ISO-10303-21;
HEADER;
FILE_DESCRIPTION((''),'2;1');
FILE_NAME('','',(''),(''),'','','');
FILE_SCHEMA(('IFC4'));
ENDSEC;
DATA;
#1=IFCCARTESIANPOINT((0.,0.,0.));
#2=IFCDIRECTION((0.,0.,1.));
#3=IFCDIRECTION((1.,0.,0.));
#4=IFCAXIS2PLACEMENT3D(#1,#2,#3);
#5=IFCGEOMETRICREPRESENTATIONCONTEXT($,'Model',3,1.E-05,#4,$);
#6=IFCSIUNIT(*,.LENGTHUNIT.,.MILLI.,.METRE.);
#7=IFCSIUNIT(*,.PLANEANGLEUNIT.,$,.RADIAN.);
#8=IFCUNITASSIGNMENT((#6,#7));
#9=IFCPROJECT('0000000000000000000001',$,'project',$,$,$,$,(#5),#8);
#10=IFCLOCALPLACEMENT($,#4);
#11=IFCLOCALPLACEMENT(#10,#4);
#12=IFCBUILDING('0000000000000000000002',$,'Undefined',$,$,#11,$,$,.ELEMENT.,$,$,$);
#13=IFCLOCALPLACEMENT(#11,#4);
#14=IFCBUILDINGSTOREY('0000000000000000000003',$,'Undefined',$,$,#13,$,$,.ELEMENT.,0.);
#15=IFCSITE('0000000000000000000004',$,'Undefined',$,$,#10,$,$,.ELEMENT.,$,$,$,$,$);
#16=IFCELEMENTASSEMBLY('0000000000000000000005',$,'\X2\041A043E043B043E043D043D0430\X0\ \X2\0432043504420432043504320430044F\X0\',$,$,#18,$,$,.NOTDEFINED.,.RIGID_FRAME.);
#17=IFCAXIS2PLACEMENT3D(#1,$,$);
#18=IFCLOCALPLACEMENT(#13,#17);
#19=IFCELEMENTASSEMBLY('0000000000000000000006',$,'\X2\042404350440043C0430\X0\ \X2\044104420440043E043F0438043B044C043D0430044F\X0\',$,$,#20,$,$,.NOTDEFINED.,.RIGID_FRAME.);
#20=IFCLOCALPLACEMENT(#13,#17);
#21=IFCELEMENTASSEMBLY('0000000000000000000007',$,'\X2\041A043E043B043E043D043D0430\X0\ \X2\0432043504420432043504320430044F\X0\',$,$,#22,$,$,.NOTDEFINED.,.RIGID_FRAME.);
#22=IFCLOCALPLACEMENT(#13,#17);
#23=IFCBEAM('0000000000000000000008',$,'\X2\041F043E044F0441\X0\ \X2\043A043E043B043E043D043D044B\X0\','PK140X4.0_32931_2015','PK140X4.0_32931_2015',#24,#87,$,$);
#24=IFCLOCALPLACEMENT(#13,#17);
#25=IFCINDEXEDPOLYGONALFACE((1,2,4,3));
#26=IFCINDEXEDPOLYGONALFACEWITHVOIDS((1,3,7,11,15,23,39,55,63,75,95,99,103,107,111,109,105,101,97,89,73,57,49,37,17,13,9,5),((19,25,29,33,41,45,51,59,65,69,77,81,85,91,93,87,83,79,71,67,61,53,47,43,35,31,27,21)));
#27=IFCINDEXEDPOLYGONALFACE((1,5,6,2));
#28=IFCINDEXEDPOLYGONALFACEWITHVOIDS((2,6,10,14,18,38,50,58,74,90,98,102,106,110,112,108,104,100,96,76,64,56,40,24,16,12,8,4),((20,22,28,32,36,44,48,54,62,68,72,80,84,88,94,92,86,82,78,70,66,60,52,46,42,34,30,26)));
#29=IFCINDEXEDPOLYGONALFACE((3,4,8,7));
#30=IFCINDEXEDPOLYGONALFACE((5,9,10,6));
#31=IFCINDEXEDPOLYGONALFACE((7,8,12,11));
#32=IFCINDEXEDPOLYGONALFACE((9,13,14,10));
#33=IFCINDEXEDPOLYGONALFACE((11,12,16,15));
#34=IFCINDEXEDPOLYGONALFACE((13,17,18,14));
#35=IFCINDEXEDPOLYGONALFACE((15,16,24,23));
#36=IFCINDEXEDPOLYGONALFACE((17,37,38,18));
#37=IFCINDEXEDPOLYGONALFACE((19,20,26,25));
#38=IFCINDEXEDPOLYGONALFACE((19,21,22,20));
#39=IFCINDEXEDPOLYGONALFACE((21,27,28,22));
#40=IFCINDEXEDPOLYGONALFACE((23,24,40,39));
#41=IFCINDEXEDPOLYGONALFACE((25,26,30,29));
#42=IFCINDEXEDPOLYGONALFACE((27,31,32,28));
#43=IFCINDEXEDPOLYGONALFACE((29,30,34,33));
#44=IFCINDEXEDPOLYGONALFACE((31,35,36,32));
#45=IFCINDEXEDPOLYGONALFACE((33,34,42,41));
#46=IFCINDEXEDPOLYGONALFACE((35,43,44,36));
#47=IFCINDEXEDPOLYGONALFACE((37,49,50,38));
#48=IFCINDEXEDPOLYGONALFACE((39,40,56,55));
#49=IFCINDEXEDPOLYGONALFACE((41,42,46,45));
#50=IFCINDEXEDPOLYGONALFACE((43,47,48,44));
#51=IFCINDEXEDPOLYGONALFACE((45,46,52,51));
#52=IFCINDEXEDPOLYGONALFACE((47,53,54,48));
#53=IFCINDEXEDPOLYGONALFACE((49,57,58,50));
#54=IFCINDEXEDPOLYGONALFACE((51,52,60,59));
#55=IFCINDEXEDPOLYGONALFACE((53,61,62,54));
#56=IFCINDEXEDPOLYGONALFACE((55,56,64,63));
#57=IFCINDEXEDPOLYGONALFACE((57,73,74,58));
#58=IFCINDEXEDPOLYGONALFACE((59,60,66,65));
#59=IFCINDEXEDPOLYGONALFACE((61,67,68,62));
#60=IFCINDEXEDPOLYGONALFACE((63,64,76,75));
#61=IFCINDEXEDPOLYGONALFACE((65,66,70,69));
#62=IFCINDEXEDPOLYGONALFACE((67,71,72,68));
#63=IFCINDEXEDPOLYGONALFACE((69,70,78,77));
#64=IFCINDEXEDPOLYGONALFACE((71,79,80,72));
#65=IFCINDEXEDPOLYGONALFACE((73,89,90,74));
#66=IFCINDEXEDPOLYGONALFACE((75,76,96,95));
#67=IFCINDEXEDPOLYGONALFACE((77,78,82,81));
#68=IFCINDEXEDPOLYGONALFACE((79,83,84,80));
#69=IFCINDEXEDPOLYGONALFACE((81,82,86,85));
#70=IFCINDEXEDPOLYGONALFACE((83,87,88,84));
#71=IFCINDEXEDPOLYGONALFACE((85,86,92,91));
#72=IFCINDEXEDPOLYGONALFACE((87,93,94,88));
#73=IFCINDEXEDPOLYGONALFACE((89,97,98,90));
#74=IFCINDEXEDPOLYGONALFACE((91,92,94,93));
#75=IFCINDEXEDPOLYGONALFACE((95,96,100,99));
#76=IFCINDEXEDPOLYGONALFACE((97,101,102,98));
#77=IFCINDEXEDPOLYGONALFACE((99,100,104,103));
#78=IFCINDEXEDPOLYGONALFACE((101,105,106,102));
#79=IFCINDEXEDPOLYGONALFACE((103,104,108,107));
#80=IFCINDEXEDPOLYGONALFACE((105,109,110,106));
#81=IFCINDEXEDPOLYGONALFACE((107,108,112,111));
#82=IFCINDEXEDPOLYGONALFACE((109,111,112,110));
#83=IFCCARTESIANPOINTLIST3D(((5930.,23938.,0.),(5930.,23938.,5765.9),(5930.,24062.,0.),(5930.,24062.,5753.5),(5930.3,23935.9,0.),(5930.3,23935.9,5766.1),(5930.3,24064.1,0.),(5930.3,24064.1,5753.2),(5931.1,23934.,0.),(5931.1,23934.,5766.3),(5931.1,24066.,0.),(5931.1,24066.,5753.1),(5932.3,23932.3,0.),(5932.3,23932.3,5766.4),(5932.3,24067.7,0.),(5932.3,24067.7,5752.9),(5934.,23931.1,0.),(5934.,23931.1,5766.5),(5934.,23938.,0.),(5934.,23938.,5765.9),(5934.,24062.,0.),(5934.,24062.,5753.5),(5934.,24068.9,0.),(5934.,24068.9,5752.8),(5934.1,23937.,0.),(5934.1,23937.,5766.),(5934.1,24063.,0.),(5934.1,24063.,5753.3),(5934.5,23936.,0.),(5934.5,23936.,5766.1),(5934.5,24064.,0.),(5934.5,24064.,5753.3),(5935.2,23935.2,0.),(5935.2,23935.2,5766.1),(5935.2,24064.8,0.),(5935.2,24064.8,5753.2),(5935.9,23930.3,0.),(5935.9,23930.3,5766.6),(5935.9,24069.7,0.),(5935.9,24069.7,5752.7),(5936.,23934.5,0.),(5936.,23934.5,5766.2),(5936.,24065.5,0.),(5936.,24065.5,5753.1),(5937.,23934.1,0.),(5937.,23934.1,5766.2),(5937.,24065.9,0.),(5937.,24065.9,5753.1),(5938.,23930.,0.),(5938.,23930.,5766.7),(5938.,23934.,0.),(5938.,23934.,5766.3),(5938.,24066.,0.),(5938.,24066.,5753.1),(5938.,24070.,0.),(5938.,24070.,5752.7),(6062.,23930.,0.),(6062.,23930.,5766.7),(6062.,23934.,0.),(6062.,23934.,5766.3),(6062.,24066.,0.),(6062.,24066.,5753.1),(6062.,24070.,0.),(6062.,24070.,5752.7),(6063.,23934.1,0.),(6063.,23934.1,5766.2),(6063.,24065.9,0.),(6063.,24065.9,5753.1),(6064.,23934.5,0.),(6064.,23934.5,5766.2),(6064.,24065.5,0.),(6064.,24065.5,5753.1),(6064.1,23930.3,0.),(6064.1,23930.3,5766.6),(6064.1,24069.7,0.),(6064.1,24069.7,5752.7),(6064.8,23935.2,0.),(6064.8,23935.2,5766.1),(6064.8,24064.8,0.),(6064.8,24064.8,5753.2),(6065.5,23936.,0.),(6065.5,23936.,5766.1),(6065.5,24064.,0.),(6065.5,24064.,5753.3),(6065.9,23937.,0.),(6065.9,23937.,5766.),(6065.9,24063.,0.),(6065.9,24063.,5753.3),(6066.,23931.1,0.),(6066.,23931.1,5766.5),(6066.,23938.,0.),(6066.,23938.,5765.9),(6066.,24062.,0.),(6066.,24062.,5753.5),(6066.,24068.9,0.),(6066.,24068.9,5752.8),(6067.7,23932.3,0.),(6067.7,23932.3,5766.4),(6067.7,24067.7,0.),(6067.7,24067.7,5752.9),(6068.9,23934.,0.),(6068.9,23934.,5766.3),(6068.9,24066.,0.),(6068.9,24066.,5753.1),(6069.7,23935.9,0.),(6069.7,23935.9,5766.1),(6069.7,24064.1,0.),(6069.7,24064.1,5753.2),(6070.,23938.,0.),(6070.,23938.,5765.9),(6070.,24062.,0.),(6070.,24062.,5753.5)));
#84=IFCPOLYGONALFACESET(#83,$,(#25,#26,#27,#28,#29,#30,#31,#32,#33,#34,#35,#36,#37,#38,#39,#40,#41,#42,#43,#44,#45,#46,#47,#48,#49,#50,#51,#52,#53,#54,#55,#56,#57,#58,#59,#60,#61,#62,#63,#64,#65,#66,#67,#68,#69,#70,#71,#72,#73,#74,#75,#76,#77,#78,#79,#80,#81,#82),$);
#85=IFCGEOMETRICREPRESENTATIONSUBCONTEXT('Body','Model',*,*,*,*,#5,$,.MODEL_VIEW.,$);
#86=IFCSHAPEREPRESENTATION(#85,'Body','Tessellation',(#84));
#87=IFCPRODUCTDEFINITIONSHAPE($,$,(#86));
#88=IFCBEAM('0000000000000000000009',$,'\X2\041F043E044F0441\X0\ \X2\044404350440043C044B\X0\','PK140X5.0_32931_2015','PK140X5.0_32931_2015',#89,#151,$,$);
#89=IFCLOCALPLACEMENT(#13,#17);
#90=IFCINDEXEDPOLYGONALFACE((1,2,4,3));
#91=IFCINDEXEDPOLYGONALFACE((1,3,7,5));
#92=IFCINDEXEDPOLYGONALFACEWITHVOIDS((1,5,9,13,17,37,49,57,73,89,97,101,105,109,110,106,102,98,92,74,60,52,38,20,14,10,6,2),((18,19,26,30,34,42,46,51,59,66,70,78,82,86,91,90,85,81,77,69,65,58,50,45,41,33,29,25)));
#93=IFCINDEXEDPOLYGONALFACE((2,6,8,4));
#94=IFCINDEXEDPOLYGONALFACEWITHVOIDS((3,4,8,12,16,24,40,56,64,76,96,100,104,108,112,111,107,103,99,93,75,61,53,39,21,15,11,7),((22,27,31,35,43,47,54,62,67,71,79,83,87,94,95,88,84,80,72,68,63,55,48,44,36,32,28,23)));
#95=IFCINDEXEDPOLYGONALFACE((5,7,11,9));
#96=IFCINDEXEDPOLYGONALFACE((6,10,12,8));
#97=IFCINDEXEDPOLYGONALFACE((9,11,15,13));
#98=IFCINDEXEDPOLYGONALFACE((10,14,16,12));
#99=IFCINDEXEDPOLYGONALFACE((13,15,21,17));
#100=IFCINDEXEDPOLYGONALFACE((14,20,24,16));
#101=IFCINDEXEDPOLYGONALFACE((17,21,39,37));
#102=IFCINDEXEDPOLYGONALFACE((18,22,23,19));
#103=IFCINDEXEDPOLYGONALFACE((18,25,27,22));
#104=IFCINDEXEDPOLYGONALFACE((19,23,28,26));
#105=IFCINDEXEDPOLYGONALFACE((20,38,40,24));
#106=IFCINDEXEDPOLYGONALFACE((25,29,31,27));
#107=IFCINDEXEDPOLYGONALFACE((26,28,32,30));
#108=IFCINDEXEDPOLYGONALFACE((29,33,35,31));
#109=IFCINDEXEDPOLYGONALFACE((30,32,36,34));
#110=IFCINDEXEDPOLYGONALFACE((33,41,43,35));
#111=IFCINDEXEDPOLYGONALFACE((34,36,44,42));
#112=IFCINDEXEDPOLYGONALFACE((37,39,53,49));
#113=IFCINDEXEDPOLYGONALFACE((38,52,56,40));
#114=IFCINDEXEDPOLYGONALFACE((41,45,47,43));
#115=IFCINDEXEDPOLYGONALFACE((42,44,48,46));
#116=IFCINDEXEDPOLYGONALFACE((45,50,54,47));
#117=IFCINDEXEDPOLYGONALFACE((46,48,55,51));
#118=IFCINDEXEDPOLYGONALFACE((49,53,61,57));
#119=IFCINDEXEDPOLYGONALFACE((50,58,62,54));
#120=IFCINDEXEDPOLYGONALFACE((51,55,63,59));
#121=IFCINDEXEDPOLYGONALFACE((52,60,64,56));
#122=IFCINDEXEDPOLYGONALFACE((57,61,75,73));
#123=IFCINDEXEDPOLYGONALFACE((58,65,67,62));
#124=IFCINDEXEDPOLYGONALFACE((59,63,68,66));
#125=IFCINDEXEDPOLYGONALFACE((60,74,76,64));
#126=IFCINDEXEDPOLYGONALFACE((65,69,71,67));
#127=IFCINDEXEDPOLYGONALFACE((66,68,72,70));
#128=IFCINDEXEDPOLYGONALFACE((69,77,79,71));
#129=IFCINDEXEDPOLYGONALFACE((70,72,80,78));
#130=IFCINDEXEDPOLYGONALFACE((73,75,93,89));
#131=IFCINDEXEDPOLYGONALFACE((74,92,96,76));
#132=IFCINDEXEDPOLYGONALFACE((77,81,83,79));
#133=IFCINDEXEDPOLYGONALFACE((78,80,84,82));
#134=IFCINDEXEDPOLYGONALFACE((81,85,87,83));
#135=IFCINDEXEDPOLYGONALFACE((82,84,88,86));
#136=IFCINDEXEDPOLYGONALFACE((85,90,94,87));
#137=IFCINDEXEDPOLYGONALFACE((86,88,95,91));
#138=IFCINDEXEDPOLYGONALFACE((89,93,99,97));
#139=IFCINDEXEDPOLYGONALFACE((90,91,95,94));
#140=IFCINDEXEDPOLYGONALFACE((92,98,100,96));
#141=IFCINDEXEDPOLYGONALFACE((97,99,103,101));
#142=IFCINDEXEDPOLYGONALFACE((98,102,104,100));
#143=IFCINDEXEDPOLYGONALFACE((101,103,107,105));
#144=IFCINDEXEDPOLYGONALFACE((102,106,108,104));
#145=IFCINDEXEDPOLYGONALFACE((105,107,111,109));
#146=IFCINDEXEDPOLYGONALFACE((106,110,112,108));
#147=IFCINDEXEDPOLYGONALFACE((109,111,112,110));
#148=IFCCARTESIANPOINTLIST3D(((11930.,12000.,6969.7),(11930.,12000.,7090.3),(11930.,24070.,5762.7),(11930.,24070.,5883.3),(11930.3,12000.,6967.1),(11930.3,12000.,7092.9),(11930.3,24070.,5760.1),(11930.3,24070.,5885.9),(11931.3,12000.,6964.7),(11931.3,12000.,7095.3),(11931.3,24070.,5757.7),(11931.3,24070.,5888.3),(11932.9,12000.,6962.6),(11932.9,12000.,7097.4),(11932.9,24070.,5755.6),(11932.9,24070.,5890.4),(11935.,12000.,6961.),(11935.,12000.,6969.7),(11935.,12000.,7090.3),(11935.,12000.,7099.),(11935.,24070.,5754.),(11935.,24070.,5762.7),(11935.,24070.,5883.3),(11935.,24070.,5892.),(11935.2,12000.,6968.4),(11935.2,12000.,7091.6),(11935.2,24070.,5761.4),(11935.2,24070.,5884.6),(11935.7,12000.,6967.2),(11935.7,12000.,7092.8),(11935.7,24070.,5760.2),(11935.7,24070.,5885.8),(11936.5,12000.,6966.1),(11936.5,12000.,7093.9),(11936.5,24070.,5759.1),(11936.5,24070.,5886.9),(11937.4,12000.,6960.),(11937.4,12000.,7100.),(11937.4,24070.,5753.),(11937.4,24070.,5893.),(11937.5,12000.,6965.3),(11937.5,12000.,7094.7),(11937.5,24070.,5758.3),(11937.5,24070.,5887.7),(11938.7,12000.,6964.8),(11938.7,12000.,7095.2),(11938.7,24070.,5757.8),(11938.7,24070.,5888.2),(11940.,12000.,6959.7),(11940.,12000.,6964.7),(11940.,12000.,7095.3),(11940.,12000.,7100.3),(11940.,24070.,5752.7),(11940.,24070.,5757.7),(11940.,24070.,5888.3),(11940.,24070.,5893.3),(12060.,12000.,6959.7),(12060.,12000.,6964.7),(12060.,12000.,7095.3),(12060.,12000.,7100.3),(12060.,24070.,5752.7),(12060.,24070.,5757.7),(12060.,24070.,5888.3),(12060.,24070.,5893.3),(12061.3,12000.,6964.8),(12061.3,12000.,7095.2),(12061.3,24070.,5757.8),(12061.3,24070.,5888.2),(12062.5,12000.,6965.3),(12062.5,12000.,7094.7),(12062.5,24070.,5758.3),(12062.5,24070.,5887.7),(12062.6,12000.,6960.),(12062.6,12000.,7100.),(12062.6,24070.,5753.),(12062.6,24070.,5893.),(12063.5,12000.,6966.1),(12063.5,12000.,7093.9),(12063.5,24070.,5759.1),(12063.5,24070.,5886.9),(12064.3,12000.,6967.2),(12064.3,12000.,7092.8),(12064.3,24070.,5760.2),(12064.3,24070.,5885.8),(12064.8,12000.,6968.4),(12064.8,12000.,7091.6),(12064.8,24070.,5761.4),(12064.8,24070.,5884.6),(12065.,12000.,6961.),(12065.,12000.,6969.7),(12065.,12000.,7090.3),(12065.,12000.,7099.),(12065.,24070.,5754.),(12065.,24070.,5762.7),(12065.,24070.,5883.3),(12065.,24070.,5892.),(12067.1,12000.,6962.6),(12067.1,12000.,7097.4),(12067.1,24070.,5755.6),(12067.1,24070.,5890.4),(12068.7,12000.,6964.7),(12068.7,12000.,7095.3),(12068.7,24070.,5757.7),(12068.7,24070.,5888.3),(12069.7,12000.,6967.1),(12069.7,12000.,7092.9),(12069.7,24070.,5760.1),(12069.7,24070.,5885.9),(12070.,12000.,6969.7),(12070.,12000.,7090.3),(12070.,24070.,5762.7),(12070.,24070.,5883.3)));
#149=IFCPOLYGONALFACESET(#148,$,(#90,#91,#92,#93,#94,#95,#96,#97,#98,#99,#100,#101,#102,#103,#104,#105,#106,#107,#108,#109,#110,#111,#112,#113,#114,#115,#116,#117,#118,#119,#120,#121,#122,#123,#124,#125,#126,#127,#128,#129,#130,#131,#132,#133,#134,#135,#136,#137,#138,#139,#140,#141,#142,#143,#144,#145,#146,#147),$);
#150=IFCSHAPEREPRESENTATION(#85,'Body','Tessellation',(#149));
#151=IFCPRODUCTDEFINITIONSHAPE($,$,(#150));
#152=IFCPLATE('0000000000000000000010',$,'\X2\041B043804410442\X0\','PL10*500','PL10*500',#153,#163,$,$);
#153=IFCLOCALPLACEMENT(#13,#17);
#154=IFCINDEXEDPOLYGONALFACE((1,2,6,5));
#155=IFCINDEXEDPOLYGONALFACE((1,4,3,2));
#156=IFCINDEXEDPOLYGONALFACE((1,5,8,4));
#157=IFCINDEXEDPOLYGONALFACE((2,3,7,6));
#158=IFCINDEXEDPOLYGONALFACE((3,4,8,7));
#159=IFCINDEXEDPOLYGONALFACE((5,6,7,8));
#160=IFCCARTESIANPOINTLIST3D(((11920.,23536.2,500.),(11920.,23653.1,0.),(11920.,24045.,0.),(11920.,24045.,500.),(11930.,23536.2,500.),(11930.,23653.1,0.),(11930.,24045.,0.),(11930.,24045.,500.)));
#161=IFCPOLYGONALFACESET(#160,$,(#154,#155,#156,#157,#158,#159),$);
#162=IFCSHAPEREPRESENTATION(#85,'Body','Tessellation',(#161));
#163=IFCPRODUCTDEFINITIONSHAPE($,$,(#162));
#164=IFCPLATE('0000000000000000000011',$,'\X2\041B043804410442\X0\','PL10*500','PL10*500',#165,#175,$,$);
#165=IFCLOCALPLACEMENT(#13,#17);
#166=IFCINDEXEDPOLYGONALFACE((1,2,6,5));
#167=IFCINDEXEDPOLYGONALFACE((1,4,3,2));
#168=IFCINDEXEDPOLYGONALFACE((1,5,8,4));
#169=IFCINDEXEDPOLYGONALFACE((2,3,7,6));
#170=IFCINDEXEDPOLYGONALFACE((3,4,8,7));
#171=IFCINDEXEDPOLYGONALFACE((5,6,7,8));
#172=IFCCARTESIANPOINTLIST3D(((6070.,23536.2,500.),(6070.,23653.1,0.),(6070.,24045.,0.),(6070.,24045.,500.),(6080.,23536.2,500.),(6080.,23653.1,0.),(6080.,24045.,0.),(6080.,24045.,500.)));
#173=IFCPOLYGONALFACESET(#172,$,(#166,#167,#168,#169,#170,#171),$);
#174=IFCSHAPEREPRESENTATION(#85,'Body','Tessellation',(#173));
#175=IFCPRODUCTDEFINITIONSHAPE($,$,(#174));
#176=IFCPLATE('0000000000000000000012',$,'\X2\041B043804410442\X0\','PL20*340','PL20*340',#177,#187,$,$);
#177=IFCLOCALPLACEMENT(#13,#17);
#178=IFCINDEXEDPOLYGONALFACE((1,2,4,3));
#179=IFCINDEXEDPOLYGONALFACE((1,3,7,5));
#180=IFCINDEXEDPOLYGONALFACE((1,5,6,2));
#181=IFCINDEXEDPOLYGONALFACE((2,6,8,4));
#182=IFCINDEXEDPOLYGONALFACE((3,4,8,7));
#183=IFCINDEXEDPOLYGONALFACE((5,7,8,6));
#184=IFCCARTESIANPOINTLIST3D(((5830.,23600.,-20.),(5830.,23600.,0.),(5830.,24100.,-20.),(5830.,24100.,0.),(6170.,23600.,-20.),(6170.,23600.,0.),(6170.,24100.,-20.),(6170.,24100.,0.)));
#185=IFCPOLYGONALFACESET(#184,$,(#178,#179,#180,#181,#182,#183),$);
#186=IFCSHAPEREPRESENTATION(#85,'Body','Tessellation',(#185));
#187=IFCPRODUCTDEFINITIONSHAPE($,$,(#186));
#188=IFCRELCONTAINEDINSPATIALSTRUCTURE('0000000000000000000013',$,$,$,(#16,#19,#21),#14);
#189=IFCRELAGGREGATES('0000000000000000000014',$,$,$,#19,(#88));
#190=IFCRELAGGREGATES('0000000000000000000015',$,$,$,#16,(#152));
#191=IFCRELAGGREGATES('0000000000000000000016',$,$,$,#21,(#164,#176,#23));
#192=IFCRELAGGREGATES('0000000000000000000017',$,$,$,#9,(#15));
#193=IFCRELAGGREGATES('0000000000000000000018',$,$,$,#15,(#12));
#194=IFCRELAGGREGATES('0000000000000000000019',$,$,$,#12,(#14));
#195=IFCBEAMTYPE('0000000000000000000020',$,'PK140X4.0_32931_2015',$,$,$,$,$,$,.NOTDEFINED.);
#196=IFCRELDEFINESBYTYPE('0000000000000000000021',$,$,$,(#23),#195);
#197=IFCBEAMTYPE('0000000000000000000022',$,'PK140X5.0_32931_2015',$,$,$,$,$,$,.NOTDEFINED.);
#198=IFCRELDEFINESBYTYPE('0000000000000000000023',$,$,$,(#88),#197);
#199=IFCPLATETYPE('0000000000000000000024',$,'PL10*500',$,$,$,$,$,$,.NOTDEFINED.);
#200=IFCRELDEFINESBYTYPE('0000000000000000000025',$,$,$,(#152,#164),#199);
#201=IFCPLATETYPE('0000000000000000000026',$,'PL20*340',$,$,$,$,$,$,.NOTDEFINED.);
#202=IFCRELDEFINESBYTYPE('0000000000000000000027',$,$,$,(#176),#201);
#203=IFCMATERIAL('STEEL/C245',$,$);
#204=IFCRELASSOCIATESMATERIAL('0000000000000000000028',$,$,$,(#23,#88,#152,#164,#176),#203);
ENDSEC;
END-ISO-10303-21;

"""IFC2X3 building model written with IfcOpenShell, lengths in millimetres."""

from ifc_helpers import new_model, si_unit, frame, origin_with_axes, origin_2d_with_axis, place, context, subcontext, project, spatial, polyline, hollow_rectangle, outline, extrude, clip, halfspace, material, type_object, element, aggregate, save


model = new_model("IFC2X3")

# Units and contexts
model_context = context("Model", 3, precision=1e-05, world=origin_with_axes())
body_context = subcontext(model_context, "Body", "Model", "MODEL_VIEW")
ifc_project = project(units=[si_unit("LENGTHUNIT", "METRE", prefix="MILLI"), si_unit("PLANEANGLEUNIT", "RADIAN")], contexts=[model_context])

# Site, building, storey
site_placement = place(None, origin_with_axes())
site = spatial("IfcSite", under=ifc_project, at=site_placement, Name="Undefined", CompositionType="ELEMENT")
building_placement = place(site_placement, origin_with_axes())
building = spatial("IfcBuilding", under=site, at=building_placement, Name="Undefined", CompositionType="ELEMENT")
storey_placement = place(building_placement, origin_with_axes())
storey = spatial("IfcBuildingStorey", under=building, at=storey_placement, Name="Undefined", CompositionType="ELEMENT", Elevation=0.0)

# Shared definitions
ifc_material_1 = material(Name="STEEL/C245")

# Element assembly
assembly_1_placement = place(storey_placement, origin_with_axes())
assembly_1 = element("IfcElementAssembly", 1, at=assembly_1_placement, inside=storey, Name="Колонна ветвевая", AssemblyPlace="NOTDEFINED", PredefinedType="RIGID_FRAME")

# Element assembly
assembly_2_placement = place(storey_placement, origin_with_axes())
assembly_2 = element("IfcElementAssembly", 2, at=assembly_2_placement, inside=storey, Name="Ферма стропильная", AssemblyPlace="NOTDEFINED", PredefinedType="RIGID_FRAME")

# Shared definitions
beam_type_1 = type_object("IfcBeamType", Name="PK140X4.0_32931_2015", PredefinedType="NOTDEFINED")

# Element assembly, beam
assembly_3_placement = place(storey_placement, origin_with_axes())
assembly_3 = element("IfcElementAssembly", 3, at=assembly_3_placement, inside=storey, Name="Колонна ветвевая", AssemblyPlace="NOTDEFINED", PredefinedType="RIGID_FRAME")
beam_1_placement = place(assembly_3_placement, frame((6000.0, 24000.0, 6000.0), z_axis=(1.0, 0.0, 0.0), x_axis=(0.0, 0.0, -1.0)))
beam_1 = element("IfcBeam", 4, at=beam_1_placement, type_object=beam_type_1, material=ifc_material_1, Name="Пояс колонны", Description="PK140X4.0_32931_2015", ObjectType="PK140X4.0_32931_2015", context=body_context, shape_type="Clipping", body=[
    clip(extrude(hollow_rectangle(XDim=140.0, YDim=140.0, WallThickness=4.0, InnerFilletRadius=4.0, OuterFilletRadius=8.0, at=origin_2d_with_axis()), frame((6000.0, 0.0, 0.0), z_axis=(-1.0, 0.0, 0.0), x_axis=(0.0, -1.0, 0.0)), (0.0, 0.0, 1.0), 5766.7), halfspace(frame((232.4, -79.1, 0.0), z_axis=(0.995037, -0.099504, 0.0), x_axis=(-0.099504, -0.995037, 0.0)), True)),
])

# Beam
beam_type_2 = type_object("IfcBeamType", Name="PK140X5.0_32931_2015", PredefinedType="NOTDEFINED")
beam_2_placement = place(assembly_2_placement, frame((12000.0, 24000.0, 5830.0), z_axis=(0.0, 0.099504, 0.995037), x_axis=(0.0, -0.995037, 0.099504)))
beam_2 = element("IfcBeam", 5, at=beam_2_placement, type_object=beam_type_2, material=ifc_material_1, Name="Пояс фермы", Description="PK140X5.0_32931_2015", ObjectType="PK140X5.0_32931_2015", context=body_context, shape_type="Clipping", body=[
    clip(clip(extrude(hollow_rectangle(XDim=140.0, YDim=140.0, WallThickness=5.0, InnerFilletRadius=5.0, OuterFilletRadius=10.0, at=origin_2d_with_axis()), frame((12074.0, 0.0, 0.0), z_axis=(-1.0, 0.0, 0.0), x_axis=(0.0, -1.0, 0.0)), (0.0, 0.0, 1.0), 12158.5), halfspace(frame((12239.3, 0.0, 1794.2), z_axis=(0.995037, 0.0, -0.099504), x_axis=(0.099504, 0.0, 0.995037)), False)), halfspace(frame((-65.6, 0.0, 47.4), z_axis=(0.995037, 0.0, -0.099504), x_axis=(0.099504, 0.0, 0.995037)), True)),
])
aggregate(assembly_2, [beam_2])

# Plates
plate_type_1 = type_object("IfcPlateType", Name="PL10*500", PredefinedType="NOTDEFINED")
plate_1_placement = place(assembly_1_placement, frame((11925.0, 24045.0, 500.0), z_axis=(-1.0, 0.0, 0.0), x_axis=(0.0, 0.0, -1.0)))
plate_1 = element("IfcPlate", 6, at=plate_1_placement, type_object=plate_type_1, material=ifc_material_1, Name="Лист", Description="PL10*500", ObjectType="PL10*500", context=body_context, shape_type="SweptSolid", body=[
    extrude(outline(polyline([(0.0, 0.0), (500.0, 0.0), (500.0, 391.9), (0.0, 508.8), (0.0, 0.0)])), frame((0.0, 0.0, -5.0), z_axis=(0.0, 0.0, 1.0), x_axis=(1.0, 0.0, 0.0)), (0.0, 0.0, 1.0), 10.0),
])
aggregate(assembly_1, [plate_1])
plate_2_placement = place(assembly_3_placement, frame((6075.0, 24045.0, 500.0), z_axis=(-1.0, 0.0, 0.0), x_axis=(0.0, 0.0, -1.0)))
plate_2 = element("IfcPlate", 7, at=plate_2_placement, type_object=plate_type_1, material=ifc_material_1, Name="Лист", Description="PL10*500", ObjectType="PL10*500", context=body_context, shape_type="SweptSolid", body=[
    extrude(outline(polyline([(0.0, 0.0), (500.0, 0.0), (500.0, 391.9), (0.0, 508.8), (0.0, 0.0)])), frame((0.0, 0.0, -5.0), z_axis=(0.0, 0.0, 1.0), x_axis=(1.0, 0.0, 0.0)), (0.0, 0.0, 1.0), 10.0),
])
plate_type_2 = type_object("IfcPlateType", Name="PL20*340", PredefinedType="NOTDEFINED")
plate_3_placement = place(assembly_3_placement, frame((6170.0, 24100.0, -10.0), z_axis=(0.0, 0.0, -1.0), x_axis=(0.0, -1.0, 0.0)))
plate_3 = element("IfcPlate", 8, at=plate_3_placement, type_object=plate_type_2, material=ifc_material_1, Name="Лист", Description="PL20*340", ObjectType="PL20*340", context=body_context, shape_type="SweptSolid", body=[
    extrude(outline(polyline([(0.0, 0.0), (500.0, 0.0), (500.0, 340.0), (0.0, 340.0), (0.0, 0.0)])), frame((0.0, 0.0, -10.0), z_axis=(0.0, 0.0, 1.0), x_axis=(1.0, 0.0, 0.0)), (0.0, 0.0, 1.0), 20.0),
])
aggregate(assembly_3, [plate_2, plate_3, beam_1])

save(model, "model.ifc")
